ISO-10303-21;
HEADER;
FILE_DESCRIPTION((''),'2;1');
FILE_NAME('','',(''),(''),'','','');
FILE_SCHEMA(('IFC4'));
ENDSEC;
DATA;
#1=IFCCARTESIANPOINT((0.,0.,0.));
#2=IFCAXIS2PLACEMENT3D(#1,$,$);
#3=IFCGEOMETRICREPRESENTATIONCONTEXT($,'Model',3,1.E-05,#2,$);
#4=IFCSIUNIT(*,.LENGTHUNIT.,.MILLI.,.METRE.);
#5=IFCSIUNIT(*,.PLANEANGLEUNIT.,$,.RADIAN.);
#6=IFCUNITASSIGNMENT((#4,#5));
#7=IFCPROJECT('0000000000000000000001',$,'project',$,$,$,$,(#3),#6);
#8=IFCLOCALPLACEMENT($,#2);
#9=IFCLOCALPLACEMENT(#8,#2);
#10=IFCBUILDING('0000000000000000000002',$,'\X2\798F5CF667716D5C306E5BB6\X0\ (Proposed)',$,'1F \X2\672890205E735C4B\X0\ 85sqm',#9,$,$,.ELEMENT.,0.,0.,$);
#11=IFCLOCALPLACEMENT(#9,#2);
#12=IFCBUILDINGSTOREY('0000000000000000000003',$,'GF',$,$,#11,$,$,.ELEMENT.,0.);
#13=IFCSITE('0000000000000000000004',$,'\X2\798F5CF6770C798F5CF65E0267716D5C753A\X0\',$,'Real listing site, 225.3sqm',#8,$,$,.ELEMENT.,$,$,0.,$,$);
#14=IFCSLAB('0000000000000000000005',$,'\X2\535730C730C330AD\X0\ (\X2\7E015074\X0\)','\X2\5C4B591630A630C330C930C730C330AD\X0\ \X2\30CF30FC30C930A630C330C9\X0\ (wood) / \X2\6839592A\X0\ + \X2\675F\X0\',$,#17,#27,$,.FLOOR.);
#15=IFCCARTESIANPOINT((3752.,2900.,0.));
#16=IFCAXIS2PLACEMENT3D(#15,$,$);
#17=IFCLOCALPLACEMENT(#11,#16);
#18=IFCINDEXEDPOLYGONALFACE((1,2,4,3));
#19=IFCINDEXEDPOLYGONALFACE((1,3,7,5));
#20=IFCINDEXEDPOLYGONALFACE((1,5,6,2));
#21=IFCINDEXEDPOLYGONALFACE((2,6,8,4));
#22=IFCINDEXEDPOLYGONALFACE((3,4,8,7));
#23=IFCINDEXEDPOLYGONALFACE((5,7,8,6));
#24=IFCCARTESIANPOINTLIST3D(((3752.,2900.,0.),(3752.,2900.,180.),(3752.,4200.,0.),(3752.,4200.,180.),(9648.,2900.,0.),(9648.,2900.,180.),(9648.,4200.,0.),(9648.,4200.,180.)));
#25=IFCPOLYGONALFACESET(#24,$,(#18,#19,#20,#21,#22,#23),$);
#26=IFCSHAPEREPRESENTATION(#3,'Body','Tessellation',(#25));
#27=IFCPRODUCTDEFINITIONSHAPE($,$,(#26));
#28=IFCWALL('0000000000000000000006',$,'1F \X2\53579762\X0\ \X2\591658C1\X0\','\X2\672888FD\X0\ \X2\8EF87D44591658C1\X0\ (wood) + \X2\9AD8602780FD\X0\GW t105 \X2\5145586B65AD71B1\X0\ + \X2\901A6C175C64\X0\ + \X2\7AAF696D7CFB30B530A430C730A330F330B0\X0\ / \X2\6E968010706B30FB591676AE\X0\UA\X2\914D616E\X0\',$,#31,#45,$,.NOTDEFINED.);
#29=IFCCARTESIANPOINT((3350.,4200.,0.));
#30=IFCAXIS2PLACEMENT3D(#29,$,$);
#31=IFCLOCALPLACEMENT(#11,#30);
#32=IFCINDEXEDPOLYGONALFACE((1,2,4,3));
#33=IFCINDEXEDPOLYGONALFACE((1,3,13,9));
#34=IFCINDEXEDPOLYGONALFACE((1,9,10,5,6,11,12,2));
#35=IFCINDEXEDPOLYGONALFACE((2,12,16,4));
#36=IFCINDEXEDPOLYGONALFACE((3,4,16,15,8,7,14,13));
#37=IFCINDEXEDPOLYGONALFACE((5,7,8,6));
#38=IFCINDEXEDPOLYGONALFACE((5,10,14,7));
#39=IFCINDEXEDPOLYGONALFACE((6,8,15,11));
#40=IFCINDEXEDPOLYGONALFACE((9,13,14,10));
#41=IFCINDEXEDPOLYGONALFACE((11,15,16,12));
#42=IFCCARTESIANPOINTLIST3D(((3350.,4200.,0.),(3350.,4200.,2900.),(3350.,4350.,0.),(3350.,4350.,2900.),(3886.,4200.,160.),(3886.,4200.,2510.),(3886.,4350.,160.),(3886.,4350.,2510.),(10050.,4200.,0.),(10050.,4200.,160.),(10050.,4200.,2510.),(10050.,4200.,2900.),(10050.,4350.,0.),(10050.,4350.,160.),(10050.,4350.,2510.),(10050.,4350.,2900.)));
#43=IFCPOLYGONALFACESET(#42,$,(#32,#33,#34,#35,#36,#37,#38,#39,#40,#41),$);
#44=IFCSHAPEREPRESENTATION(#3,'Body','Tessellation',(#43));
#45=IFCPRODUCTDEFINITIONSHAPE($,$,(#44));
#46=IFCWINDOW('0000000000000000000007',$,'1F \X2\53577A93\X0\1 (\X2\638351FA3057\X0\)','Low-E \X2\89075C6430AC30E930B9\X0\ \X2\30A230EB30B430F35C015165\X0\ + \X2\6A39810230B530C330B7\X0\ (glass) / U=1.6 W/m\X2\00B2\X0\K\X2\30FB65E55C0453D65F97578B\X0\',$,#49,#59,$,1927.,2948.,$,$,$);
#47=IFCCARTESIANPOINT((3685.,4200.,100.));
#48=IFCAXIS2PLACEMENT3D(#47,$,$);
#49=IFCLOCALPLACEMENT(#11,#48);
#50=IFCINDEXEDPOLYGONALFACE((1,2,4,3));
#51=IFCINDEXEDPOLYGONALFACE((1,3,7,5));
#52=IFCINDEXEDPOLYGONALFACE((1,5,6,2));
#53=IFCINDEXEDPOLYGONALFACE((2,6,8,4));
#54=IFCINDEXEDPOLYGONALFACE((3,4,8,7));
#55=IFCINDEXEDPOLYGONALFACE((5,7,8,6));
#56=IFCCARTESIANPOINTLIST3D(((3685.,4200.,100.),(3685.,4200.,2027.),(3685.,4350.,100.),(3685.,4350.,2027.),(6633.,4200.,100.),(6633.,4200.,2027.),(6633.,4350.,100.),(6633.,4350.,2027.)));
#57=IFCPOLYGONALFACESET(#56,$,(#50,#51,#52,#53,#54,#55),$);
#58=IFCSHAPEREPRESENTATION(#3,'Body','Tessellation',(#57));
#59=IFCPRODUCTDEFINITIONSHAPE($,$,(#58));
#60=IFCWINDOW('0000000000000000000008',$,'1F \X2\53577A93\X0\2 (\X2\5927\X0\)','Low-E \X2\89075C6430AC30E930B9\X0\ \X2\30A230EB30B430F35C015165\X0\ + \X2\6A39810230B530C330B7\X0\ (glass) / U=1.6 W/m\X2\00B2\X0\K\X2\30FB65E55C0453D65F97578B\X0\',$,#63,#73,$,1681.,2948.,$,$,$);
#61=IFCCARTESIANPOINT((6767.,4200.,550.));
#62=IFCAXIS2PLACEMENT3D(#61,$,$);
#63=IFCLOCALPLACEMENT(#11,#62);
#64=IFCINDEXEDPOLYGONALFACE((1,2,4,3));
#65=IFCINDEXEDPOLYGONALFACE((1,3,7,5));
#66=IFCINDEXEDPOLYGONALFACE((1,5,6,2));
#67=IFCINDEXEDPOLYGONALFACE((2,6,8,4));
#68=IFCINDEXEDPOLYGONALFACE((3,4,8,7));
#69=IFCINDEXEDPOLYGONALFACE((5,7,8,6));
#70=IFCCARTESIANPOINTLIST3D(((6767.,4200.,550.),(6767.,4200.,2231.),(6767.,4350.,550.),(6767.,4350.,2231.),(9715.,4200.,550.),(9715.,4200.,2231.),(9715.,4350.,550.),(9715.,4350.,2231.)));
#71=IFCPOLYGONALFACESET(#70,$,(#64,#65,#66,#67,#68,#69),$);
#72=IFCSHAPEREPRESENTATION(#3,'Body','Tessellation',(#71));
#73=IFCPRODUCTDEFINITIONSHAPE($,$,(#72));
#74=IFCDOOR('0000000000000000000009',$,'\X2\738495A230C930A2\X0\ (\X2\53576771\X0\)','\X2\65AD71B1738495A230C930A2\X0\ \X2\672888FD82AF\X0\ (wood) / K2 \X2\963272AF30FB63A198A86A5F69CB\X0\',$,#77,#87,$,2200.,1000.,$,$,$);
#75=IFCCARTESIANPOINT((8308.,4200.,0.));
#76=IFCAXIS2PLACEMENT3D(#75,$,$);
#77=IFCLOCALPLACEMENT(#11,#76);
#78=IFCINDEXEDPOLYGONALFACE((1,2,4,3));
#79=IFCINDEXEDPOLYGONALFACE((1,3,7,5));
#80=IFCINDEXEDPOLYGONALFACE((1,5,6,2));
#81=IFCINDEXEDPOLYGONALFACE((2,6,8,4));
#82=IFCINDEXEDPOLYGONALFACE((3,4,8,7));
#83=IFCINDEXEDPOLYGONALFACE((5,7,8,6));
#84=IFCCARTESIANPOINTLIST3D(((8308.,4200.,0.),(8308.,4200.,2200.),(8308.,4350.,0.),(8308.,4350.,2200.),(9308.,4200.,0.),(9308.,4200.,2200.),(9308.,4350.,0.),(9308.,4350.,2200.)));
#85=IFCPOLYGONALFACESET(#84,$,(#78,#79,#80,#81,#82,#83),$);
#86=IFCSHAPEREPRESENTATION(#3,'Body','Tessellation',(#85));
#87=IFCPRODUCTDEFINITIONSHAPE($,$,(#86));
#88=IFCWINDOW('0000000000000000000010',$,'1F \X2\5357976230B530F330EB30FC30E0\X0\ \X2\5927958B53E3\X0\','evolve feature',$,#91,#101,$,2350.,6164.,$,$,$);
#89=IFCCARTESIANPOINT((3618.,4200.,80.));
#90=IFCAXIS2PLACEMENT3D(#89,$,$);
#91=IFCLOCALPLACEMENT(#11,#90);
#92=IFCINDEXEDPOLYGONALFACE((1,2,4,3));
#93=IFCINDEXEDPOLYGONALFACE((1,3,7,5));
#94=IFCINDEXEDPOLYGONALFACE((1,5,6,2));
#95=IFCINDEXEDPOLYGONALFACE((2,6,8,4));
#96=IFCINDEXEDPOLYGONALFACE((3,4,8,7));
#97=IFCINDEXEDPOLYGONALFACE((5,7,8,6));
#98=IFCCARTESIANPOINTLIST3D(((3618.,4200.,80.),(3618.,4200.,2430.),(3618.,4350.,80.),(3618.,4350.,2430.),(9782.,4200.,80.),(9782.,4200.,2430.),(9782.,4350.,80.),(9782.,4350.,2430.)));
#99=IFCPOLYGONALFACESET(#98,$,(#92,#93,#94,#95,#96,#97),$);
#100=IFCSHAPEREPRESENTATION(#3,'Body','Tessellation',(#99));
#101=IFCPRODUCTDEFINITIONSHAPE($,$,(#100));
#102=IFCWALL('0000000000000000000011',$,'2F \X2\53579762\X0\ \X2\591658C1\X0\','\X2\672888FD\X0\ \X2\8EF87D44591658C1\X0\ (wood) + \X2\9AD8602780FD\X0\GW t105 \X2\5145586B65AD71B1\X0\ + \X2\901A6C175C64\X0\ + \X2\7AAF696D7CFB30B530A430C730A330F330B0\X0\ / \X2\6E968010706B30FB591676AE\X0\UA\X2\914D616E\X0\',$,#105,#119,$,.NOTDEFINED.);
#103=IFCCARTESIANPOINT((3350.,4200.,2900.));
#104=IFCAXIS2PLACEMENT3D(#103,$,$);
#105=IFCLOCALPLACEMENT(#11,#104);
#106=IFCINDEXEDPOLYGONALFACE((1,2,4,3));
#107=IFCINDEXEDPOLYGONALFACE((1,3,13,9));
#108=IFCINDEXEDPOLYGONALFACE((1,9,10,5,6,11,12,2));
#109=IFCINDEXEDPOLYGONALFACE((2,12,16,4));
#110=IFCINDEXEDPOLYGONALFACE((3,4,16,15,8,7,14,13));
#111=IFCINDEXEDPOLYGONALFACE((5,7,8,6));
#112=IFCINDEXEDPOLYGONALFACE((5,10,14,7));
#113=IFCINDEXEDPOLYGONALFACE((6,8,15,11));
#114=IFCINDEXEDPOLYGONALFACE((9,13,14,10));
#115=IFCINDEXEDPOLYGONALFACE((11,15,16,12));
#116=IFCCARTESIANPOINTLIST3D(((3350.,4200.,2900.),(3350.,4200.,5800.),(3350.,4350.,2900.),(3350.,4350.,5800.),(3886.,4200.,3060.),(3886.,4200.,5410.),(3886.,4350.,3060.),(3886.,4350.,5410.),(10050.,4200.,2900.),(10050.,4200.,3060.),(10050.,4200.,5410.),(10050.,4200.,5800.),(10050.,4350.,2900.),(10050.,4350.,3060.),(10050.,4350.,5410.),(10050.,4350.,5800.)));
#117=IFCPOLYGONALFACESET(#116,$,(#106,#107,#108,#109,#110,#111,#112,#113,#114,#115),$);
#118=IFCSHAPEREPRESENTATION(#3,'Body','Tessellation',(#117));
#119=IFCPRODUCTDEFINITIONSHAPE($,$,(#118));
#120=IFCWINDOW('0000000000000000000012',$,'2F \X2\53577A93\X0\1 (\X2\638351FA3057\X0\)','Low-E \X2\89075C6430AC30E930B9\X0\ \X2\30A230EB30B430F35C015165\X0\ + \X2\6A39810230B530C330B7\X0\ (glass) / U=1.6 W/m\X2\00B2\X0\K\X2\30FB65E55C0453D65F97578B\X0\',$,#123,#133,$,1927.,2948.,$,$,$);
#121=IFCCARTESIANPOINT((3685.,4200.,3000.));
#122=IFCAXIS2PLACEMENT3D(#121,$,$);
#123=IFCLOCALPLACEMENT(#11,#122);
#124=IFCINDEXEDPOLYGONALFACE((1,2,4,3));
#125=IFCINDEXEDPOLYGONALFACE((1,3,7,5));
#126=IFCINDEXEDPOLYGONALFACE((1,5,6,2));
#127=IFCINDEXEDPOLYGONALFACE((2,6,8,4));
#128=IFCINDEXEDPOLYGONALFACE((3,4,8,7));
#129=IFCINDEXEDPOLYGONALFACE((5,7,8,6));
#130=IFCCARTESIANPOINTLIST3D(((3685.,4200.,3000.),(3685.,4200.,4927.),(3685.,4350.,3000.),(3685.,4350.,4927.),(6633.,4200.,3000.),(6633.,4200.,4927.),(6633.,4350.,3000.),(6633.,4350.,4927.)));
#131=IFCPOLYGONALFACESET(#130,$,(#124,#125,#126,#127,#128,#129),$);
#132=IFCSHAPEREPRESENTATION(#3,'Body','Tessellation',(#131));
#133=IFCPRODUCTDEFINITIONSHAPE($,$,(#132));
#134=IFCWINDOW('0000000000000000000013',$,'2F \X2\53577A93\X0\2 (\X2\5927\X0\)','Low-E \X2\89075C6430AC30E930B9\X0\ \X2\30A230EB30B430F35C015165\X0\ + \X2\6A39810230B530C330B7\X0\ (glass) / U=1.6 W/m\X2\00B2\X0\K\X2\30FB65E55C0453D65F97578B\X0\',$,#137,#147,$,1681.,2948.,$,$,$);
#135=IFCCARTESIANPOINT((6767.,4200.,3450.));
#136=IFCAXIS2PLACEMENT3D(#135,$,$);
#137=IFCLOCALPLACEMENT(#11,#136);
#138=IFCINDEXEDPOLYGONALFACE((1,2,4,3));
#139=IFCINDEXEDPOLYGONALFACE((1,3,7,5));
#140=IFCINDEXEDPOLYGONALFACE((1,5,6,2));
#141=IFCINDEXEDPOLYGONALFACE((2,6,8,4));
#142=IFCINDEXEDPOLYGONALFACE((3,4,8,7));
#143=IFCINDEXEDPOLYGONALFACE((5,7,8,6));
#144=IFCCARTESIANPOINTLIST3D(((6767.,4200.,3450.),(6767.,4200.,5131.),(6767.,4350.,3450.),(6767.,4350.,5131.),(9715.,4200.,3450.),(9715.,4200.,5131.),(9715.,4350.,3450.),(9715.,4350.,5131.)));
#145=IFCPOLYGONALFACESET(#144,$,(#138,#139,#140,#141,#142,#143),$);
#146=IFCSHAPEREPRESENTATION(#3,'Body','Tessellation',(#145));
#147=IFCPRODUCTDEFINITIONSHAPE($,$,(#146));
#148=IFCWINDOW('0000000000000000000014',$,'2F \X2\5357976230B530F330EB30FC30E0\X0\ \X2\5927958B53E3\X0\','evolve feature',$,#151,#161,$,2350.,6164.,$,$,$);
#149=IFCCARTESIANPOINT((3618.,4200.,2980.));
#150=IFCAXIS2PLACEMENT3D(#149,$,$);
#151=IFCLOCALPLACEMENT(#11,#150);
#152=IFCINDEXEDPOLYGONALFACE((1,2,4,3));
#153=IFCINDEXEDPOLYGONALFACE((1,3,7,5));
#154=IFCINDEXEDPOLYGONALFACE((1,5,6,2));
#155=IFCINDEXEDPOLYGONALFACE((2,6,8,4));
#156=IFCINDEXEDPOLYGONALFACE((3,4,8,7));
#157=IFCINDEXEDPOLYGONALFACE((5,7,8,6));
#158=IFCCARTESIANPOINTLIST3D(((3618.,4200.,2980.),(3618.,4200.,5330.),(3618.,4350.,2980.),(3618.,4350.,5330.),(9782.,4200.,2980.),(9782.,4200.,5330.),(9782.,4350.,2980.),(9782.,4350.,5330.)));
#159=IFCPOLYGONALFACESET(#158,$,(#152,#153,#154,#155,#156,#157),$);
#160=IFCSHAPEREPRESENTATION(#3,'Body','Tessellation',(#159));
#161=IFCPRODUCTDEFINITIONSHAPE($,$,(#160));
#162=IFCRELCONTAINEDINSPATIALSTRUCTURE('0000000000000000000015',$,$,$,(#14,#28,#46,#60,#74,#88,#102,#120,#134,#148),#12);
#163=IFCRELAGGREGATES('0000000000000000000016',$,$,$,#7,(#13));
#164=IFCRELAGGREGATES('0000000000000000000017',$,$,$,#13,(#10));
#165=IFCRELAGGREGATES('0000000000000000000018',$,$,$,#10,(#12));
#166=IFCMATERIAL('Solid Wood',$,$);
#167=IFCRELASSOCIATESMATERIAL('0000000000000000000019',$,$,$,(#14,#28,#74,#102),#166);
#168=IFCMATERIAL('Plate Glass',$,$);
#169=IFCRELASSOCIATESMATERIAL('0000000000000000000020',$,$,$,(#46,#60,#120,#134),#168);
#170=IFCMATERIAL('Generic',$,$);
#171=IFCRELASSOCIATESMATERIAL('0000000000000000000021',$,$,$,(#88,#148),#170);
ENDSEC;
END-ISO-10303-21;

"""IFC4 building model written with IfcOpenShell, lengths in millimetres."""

from ifc_helpers import new_model, si_unit, frame, frame_2d, origin, place, context, project, spatial, rectangle, extrude, material, element, fill, save


model = new_model("IFC4")

# Units and contexts
model_context = context("Model", 3, precision=1e-05, world=origin())
ifc_project = project(units=[si_unit("LENGTHUNIT", "METRE", prefix="MILLI"), si_unit("PLANEANGLEUNIT", "RADIAN")], contexts=[model_context])

# Site, building, storey
site_placement = place(None, origin())
site = spatial("IfcSite", under=ifc_project, at=site_placement, Name="福島県福島市東浜町", ObjectType="Real listing site, 225.3sqm", CompositionType="ELEMENT", RefElevation=0.0)
building_placement = place(site_placement, origin())
building = spatial("IfcBuilding", under=site, at=building_placement, Name="福島東浜の家 (Proposed)", ObjectType="1F 木造平屋 85sqm", CompositionType="ELEMENT", ElevationOfRefHeight=0.0, ElevationOfTerrain=0.0)
storey_placement = place(building_placement, origin())
storey = spatial("IfcBuildingStorey", under=building, at=storey_placement, Name="GF", CompositionType="ELEMENT", Elevation=0.0)

# Slab
ifc_material_1 = material(Name="Solid Wood")
slab_1_placement = place(storey_placement, frame((3752.0, 2900.0, 0.0)))
element("IfcSlab", 1, at=slab_1_placement, inside=storey, material=ifc_material_1, Name="南デッキ (縁側)", Description="屋外ウッドデッキ ハードウッド (wood) / 根太 + 束", PredefinedType="FLOOR", context=model_context, shape_type="SweptSolid", body=[
    extrude(rectangle(XDim=5896.0, YDim=1300.0, at=frame_2d((2948.0, 650.0))), frame((3752.0, 2900.0, 0.0)), (0.0, 0.0, 1.0), 180.0),
])
ifc_material_2 = material(Name="Generic")

# Wall, openings, windows, door
wall_1_placement = place(storey_placement, frame((3350.0, 4200.0, 0.0)))
wall_1 = element("IfcWall", 2, at=wall_1_placement, inside=storey, material=ifc_material_1, Name="1F 南面 外壁", Description="木製 軸組外壁 (wood) + 高性能GW t105 充填断熱 + 通気層 + 窯業系サイディング / 準耐火・外皮UA配慮", PredefinedType="NOTDEFINED", context=model_context, shape_type="SweptSolid", body=[
    extrude(rectangle(XDim=6700.0, YDim=150.0, at=frame_2d((3350.0, 75.0))), frame((3350.0, 4200.0, 0.0)), (0.0, 0.0, 1.0), 2900.0),
])
opening_1_placement = place(storey_placement, frame((3685.0, 4200.0, 100.0)))
opening_1 = element("IfcOpeningElement", 3, at=opening_1_placement, cuts=wall_1, PredefinedType="NOTDEFINED", context=model_context, shape_type="SweptSolid", body=[
    extrude(rectangle(XDim=2948.0, YDim=150.0, at=frame_2d((1474.0, 75.0))), frame((3685.0, 4200.0, 100.0)), (0.0, 0.0, 1.0), 1927.0),
])
opening_2_placement = place(storey_placement, frame((6767.0, 4200.0, 550.0)))
opening_2 = element("IfcOpeningElement", 4, at=opening_2_placement, cuts=wall_1, PredefinedType="NOTDEFINED", context=model_context, shape_type="SweptSolid", body=[
    extrude(rectangle(XDim=2948.0, YDim=150.0, at=frame_2d((1474.0, 75.0))), frame((6767.0, 4200.0, 550.0)), (0.0, 0.0, 1.0), 1681.0),
])
opening_3_placement = place(storey_placement, frame((8308.0, 4200.0, 0.0)))
opening_3 = element("IfcOpeningElement", 5, at=opening_3_placement, cuts=wall_1, PredefinedType="NOTDEFINED", context=model_context, shape_type="SweptSolid", body=[
    extrude(rectangle(XDim=1000.0, YDim=150.0, at=frame_2d((500.0, 75.0))), frame((8308.0, 4200.0, 0.0)), (0.0, 0.0, 1.0), 2200.0),
])
opening_4_placement = place(storey_placement, frame((3618.0, 4200.0, 80.0)))
opening_4 = element("IfcOpeningElement", 6, at=opening_4_placement, cuts=wall_1, PredefinedType="NOTDEFINED", context=model_context, shape_type="SweptSolid", body=[
    extrude(rectangle(XDim=6164.0, YDim=150.0, at=frame_2d((3082.0, 75.0))), frame((3618.0, 4200.0, 80.0)), (0.0, 0.0, 1.0), 2350.0),
])
ifc_material_3 = material(Name="Plate Glass")
window_1_placement = place(storey_placement, frame((3685.0, 4200.0, 100.0)))
window_1 = element("IfcWindow", 7, at=window_1_placement, inside=storey, material=ifc_material_3, Name="1F 南窓1 (掃出し)", Description="Low-E 複層ガラス アルゴン封入 + 樹脂サッシ (glass) / U=1.6 W/m²K・日射取得型", OverallHeight=1927.0, OverallWidth=2948.0, context=model_context, shape_type="SweptSolid", body=[
    extrude(rectangle(XDim=2948.0, YDim=150.0, at=frame_2d((1474.0, 75.0))), frame((3685.0, 4200.0, 100.0)), (0.0, 0.0, 1.0), 1927.0),
])
fill(opening_1, window_1)
window_2_placement = place(storey_placement, frame((6767.0, 4200.0, 550.0)))
window_2 = element("IfcWindow", 8, at=window_2_placement, inside=storey, material=ifc_material_3, Name="1F 南窓2 (大)", Description="Low-E 複層ガラス アルゴン封入 + 樹脂サッシ (glass) / U=1.6 W/m²K・日射取得型", OverallHeight=1681.0, OverallWidth=2948.0, context=model_context, shape_type="SweptSolid", body=[
    extrude(rectangle(XDim=2948.0, YDim=150.0, at=frame_2d((1474.0, 75.0))), frame((6767.0, 4200.0, 550.0)), (0.0, 0.0, 1.0), 1681.0),
])
fill(opening_2, window_2)
door_placement = place(storey_placement, frame((8308.0, 4200.0, 0.0)))
door = element("IfcDoor", 9, at=door_placement, inside=storey, material=ifc_material_1, Name="玄関ドア (南東)", Description="断熱玄関ドア 木製芯 (wood) / K2 防犯・採風機構", OverallHeight=2200.0, OverallWidth=1000.0, context=model_context, shape_type="SweptSolid", body=[
    extrude(rectangle(XDim=1000.0, YDim=150.0, at=frame_2d((500.0, 75.0))), frame((8308.0, 4200.0, 0.0)), (0.0, 0.0, 1.0), 2200.0),
])
fill(opening_3, door)
window_3_placement = place(storey_placement, frame((3618.0, 4200.0, 80.0)))
window_3 = element("IfcWindow", 10, at=window_3_placement, inside=storey, material=ifc_material_2, Name="1F 南面サンルーム 大開口", Description="evolve feature", OverallHeight=2350.0, OverallWidth=6164.0, context=model_context, shape_type="SweptSolid", body=[
    extrude(rectangle(XDim=6164.0, YDim=150.0, at=frame_2d((3082.0, 75.0))), frame((3618.0, 4200.0, 80.0)), (0.0, 0.0, 1.0), 2350.0),
])
fill(opening_4, window_3)

# Wall, openings, windows
wall_2_placement = place(storey_placement, frame((3350.0, 4200.0, 2900.0)))
wall_2 = element("IfcWall", 11, at=wall_2_placement, inside=storey, material=ifc_material_1, Name="2F 南面 外壁", Description="木製 軸組外壁 (wood) + 高性能GW t105 充填断熱 + 通気層 + 窯業系サイディング / 準耐火・外皮UA配慮", PredefinedType="NOTDEFINED", context=model_context, shape_type="SweptSolid", body=[
    extrude(rectangle(XDim=6700.0, YDim=150.0, at=frame_2d((3350.0, 75.0))), frame((3350.0, 4200.0, 2900.0)), (0.0, 0.0, 1.0), 2900.0),
])
opening_5_placement = place(storey_placement, frame((3685.0, 4200.0, 3000.0)))
opening_5 = element("IfcOpeningElement", 12, at=opening_5_placement, cuts=wall_2, PredefinedType="NOTDEFINED", context=model_context, shape_type="SweptSolid", body=[
    extrude(rectangle(XDim=2948.0, YDim=150.0, at=frame_2d((1474.0, 75.0))), frame((3685.0, 4200.0, 3000.0)), (0.0, 0.0, 1.0), 1927.0),
])
opening_6_placement = place(storey_placement, frame((6767.0, 4200.0, 3450.0)))
opening_6 = element("IfcOpeningElement", 13, at=opening_6_placement, cuts=wall_2, PredefinedType="NOTDEFINED", context=model_context, shape_type="SweptSolid", body=[
    extrude(rectangle(XDim=2948.0, YDim=150.0, at=frame_2d((1474.0, 75.0))), frame((6767.0, 4200.0, 3450.0)), (0.0, 0.0, 1.0), 1681.0),
])
opening_7_placement = place(storey_placement, frame((3618.0, 4200.0, 2980.0)))
opening_7 = element("IfcOpeningElement", 14, at=opening_7_placement, cuts=wall_2, PredefinedType="NOTDEFINED", context=model_context, shape_type="SweptSolid", body=[
    extrude(rectangle(XDim=6164.0, YDim=150.0, at=frame_2d((3082.0, 75.0))), frame((3618.0, 4200.0, 2980.0)), (0.0, 0.0, 1.0), 2350.0),
])
window_4_placement = place(storey_placement, frame((3685.0, 4200.0, 3000.0)))
window_4 = element("IfcWindow", 15, at=window_4_placement, inside=storey, material=ifc_material_3, Name="2F 南窓1 (掃出し)", Description="Low-E 複層ガラス アルゴン封入 + 樹脂サッシ (glass) / U=1.6 W/m²K・日射取得型", OverallHeight=1927.0, OverallWidth=2948.0, context=model_context, shape_type="SweptSolid", body=[
    extrude(rectangle(XDim=2948.0, YDim=150.0, at=frame_2d((1474.0, 75.0))), frame((3685.0, 4200.0, 3000.0)), (0.0, 0.0, 1.0), 1927.0),
])
fill(opening_5, window_4)
window_5_placement = place(storey_placement, frame((6767.0, 4200.0, 3450.0)))
window_5 = element("IfcWindow", 16, at=window_5_placement, inside=storey, material=ifc_material_3, Name="2F 南窓2 (大)", Description="Low-E 複層ガラス アルゴン封入 + 樹脂サッシ (glass) / U=1.6 W/m²K・日射取得型", OverallHeight=1681.0, OverallWidth=2948.0, context=model_context, shape_type="SweptSolid", body=[
    extrude(rectangle(XDim=2948.0, YDim=150.0, at=frame_2d((1474.0, 75.0))), frame((6767.0, 4200.0, 3450.0)), (0.0, 0.0, 1.0), 1681.0),
])
fill(opening_6, window_5)
window_6_placement = place(storey_placement, frame((3618.0, 4200.0, 2980.0)))
window_6 = element("IfcWindow", 17, at=window_6_placement, inside=storey, material=ifc_material_2, Name="2F 南面サンルーム 大開口", Description="evolve feature", OverallHeight=2350.0, OverallWidth=6164.0, context=model_context, shape_type="SweptSolid", body=[
    extrude(rectangle(XDim=6164.0, YDim=150.0, at=frame_2d((3082.0, 75.0))), frame((3618.0, 4200.0, 2980.0)), (0.0, 0.0, 1.0), 2350.0),
])
fill(opening_7, window_6)

save(model, "model.ifc")
